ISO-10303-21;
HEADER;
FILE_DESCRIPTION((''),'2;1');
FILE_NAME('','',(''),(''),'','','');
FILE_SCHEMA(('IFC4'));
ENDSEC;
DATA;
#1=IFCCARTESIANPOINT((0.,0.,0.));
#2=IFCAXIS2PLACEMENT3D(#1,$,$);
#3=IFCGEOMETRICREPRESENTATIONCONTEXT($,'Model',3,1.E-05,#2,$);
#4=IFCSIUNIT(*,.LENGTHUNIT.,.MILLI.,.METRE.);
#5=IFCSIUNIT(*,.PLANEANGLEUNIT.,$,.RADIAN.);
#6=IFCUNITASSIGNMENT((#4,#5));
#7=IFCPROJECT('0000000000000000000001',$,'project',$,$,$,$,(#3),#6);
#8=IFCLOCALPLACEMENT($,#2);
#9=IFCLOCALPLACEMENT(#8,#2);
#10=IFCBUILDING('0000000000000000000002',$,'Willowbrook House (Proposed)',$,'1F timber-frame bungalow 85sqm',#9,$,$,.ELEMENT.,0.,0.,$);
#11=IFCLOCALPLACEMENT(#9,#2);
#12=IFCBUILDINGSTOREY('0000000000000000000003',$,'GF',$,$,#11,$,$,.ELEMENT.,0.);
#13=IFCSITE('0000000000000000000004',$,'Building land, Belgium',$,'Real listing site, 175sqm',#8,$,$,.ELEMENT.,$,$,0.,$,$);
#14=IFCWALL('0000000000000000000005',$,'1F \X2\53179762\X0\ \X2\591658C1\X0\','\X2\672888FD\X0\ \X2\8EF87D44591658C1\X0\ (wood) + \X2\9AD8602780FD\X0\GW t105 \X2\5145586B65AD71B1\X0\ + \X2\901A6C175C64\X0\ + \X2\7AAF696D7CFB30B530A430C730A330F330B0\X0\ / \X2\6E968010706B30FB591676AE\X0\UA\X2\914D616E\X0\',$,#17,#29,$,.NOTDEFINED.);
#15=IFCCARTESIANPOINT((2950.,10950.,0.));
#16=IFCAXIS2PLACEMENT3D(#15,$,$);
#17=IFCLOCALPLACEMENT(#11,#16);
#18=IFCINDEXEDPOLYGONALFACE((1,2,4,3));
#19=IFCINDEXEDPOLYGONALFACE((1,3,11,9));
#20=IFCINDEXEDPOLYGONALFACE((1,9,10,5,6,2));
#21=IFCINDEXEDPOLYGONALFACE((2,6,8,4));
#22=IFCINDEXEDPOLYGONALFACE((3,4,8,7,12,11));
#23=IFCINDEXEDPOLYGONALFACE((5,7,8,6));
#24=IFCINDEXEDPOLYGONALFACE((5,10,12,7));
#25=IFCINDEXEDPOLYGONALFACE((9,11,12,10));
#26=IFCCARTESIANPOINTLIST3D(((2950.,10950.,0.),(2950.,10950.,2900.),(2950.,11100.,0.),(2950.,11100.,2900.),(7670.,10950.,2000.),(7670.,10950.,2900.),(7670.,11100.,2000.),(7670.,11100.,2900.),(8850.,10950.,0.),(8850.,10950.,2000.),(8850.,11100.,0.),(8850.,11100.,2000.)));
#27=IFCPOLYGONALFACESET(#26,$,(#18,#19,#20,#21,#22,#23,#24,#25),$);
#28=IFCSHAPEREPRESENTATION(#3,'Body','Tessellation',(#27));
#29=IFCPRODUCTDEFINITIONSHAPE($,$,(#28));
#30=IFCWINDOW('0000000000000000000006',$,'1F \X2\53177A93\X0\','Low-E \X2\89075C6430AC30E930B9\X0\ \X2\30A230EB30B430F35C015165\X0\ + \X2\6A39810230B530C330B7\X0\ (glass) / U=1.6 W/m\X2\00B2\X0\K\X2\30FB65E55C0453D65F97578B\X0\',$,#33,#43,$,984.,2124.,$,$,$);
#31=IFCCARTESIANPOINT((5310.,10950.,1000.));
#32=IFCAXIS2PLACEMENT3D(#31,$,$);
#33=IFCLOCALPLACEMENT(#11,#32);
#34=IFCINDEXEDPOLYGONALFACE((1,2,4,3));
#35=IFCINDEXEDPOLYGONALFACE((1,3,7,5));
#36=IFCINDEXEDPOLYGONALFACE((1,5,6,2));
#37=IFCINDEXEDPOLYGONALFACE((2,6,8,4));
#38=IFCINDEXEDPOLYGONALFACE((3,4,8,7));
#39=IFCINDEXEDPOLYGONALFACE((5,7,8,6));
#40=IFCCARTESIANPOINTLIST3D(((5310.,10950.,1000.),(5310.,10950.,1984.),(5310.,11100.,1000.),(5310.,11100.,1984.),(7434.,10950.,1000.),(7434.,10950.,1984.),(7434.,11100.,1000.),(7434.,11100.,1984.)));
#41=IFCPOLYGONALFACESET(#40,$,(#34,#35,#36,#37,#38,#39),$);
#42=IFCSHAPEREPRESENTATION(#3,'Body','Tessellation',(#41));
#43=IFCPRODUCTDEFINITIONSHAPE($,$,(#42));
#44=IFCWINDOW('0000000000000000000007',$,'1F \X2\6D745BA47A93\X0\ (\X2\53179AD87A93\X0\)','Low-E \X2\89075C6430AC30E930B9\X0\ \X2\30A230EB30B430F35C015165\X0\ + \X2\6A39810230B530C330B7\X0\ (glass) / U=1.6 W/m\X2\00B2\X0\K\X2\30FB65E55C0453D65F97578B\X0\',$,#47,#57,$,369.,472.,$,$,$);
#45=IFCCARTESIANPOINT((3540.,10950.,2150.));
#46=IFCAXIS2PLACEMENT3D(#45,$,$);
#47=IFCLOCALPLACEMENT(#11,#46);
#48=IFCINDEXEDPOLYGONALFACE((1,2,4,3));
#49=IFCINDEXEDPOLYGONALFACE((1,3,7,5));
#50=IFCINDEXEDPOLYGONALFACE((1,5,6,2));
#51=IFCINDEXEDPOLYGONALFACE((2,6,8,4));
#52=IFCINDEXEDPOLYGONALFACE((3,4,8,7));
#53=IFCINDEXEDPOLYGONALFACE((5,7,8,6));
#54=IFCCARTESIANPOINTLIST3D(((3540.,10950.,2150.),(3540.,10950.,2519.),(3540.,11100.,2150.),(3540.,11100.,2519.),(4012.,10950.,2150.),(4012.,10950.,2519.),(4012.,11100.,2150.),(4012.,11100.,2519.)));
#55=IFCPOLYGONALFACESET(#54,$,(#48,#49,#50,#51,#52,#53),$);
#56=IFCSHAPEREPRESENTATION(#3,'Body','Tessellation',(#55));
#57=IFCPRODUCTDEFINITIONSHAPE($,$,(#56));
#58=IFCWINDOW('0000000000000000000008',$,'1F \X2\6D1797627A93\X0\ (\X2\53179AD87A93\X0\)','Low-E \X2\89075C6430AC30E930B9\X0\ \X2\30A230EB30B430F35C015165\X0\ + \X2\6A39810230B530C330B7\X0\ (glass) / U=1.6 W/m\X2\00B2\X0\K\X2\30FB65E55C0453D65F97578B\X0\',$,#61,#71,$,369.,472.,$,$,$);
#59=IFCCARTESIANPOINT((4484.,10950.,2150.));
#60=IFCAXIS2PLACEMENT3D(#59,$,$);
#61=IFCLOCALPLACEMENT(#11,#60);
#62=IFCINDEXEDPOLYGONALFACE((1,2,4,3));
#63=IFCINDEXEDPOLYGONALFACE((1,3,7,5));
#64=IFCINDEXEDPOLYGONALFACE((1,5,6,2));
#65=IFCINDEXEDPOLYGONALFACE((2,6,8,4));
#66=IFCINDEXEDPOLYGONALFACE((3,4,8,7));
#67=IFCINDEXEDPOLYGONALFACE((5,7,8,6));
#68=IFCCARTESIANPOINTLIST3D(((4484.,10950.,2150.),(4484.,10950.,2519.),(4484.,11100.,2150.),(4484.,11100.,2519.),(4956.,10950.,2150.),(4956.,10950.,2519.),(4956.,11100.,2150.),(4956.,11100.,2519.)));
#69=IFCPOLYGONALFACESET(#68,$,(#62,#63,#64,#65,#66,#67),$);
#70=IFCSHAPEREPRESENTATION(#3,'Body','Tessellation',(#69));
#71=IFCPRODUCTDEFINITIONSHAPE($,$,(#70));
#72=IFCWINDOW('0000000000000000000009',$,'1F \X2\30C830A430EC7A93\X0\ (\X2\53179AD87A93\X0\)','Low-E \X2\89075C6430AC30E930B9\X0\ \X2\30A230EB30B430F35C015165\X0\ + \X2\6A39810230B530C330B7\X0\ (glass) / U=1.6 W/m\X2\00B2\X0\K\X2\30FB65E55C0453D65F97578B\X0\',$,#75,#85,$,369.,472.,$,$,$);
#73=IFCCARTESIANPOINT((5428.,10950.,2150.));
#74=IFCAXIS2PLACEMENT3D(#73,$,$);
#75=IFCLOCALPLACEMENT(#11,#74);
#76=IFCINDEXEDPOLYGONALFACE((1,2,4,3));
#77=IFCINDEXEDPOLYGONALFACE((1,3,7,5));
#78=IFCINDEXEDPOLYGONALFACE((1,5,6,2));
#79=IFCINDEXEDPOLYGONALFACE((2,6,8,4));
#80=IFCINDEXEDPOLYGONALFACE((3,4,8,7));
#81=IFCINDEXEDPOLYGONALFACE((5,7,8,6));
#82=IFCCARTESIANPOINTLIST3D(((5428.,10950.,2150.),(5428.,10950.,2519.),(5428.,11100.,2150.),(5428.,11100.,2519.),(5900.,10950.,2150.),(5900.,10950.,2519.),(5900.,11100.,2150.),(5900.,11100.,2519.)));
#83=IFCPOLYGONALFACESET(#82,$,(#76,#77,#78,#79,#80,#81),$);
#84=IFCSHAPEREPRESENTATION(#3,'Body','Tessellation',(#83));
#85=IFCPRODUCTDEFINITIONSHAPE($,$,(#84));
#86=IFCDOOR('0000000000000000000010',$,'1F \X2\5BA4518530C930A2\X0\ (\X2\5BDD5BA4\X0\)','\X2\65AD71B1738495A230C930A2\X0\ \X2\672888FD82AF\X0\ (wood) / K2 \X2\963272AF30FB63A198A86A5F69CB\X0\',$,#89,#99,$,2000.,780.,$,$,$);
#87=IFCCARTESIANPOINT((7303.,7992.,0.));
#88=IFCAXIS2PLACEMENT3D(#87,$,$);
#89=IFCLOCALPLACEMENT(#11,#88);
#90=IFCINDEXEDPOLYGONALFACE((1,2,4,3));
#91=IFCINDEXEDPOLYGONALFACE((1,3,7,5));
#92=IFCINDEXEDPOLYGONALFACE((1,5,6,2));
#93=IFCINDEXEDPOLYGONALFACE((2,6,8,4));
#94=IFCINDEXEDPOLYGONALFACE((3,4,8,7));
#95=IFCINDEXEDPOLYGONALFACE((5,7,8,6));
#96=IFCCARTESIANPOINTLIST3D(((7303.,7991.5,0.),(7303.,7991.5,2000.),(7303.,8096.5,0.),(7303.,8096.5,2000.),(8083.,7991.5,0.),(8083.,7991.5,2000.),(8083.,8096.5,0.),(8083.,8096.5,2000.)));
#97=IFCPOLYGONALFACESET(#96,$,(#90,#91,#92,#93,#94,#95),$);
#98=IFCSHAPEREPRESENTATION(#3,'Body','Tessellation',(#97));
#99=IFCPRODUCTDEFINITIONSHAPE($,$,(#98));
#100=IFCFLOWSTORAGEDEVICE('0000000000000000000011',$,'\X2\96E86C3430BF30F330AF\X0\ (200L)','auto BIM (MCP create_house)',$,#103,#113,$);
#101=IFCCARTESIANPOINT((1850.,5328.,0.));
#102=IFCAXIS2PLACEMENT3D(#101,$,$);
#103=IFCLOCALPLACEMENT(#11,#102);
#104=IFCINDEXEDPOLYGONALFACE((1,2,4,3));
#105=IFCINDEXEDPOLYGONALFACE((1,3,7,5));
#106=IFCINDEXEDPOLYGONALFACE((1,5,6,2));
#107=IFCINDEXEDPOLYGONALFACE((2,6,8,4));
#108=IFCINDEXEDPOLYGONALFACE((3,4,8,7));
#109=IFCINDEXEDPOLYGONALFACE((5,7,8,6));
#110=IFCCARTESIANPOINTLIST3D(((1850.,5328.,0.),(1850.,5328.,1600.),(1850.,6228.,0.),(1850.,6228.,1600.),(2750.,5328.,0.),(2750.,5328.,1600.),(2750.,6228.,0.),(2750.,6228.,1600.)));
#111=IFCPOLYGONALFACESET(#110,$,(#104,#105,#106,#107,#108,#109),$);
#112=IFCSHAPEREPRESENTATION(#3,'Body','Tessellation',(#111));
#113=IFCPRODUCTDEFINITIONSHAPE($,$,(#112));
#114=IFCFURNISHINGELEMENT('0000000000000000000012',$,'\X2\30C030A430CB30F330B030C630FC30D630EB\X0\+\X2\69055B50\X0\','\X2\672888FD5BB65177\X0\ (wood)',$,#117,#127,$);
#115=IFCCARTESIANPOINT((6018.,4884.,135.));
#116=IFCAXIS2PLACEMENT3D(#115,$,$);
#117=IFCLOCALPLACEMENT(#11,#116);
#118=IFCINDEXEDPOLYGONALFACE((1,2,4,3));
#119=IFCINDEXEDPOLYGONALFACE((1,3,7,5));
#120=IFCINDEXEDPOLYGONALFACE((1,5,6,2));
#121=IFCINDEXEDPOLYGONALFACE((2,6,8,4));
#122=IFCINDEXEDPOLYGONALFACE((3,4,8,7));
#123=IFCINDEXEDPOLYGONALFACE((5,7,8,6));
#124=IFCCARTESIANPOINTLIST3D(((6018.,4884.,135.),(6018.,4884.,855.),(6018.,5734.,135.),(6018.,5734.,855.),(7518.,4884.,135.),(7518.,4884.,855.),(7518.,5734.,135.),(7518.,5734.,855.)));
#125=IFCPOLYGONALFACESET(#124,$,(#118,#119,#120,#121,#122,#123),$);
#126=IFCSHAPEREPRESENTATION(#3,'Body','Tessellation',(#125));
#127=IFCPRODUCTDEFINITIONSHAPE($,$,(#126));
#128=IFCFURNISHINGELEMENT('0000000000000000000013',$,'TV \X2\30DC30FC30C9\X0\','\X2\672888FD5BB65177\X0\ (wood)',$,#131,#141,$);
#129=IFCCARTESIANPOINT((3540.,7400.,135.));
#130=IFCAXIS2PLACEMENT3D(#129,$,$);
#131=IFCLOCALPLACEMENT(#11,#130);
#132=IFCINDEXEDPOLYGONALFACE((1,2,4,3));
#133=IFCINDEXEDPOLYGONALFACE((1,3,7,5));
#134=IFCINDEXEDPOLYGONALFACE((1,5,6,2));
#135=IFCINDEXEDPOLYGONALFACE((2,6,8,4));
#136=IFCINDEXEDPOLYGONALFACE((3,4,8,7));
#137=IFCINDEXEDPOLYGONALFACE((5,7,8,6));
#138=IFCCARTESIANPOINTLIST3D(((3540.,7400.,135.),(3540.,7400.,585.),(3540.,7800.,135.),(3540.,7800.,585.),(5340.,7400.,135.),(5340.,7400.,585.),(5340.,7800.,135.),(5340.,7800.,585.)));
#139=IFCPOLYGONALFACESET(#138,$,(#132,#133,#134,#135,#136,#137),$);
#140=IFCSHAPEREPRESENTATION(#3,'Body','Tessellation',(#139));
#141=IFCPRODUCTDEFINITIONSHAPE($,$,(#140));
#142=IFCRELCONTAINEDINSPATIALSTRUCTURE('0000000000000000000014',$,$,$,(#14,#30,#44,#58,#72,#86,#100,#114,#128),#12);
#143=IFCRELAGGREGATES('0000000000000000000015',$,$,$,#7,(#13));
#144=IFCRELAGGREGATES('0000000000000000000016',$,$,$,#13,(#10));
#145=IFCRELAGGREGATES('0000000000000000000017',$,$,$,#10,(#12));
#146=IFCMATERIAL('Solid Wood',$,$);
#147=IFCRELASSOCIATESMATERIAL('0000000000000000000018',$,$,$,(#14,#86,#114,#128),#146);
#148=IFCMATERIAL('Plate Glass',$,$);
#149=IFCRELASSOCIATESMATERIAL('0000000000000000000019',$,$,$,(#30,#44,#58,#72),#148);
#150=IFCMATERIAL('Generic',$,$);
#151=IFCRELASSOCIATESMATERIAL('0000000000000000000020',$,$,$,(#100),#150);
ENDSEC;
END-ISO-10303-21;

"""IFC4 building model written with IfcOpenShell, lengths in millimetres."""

from ifc_helpers import new_model, si_unit, frame, frame_2d, origin, place, context, project, spatial, rectangle, extrude, material, element, fill, save


model = new_model("IFC4")

# Units and contexts
model_context = context("Model", 3, precision=1e-05, world=origin())
ifc_project = project(units=[si_unit("LENGTHUNIT", "METRE", prefix="MILLI"), si_unit("PLANEANGLEUNIT", "RADIAN")], contexts=[model_context])

# Site, building, storey
site_placement = place(None, origin())
site = spatial("IfcSite", under=ifc_project, at=site_placement, Name="Building land, Belgium", ObjectType="Real listing site, 175sqm", CompositionType="ELEMENT", RefElevation=0.0)
building_placement = place(site_placement, origin())
building = spatial("IfcBuilding", under=site, at=building_placement, Name="Willowbrook House (Proposed)", ObjectType="1F timber-frame bungalow 85sqm", CompositionType="ELEMENT", ElevationOfRefHeight=0.0, ElevationOfTerrain=0.0)
storey_placement = place(building_placement, origin())
storey = spatial("IfcBuildingStorey", under=building, at=storey_placement, Name="GF", CompositionType="ELEMENT", Elevation=0.0)

# Wall, openings, windows
ifc_material_1 = material(Name="Solid Wood")
wall_1_placement = place(storey_placement, frame((2950.0, 10950.0, 0.0)))
wall_1 = element("IfcWall", 1, at=wall_1_placement, inside=storey, material=ifc_material_1, Name="1F 北面 外壁", Description="木製 軸組外壁 (wood) + 高性能GW t105 充填断熱 + 通気層 + 窯業系サイディング / 準耐火・外皮UA配慮", PredefinedType="NOTDEFINED", context=model_context, shape_type="SweptSolid", body=[
    extrude(rectangle(XDim=5900.0, YDim=150.0, at=frame_2d((2950.0, 75.0))), frame((2950.0, 10950.0, 0.0)), (0.0, 0.0, 1.0), 2900.0),
])
opening_1_placement = place(storey_placement, frame((5310.0, 10950.0, 1000.0)))
opening_1 = element("IfcOpeningElement", 2, at=opening_1_placement, cuts=wall_1, PredefinedType="NOTDEFINED", context=model_context, shape_type="SweptSolid", body=[
    extrude(rectangle(XDim=2124.0, YDim=150.0, at=frame_2d((1062.0, 75.0))), frame((5310.0, 10950.0, 1000.0)), (0.0, 0.0, 1.0), 984.0),
])
opening_2_placement = place(storey_placement, frame((3540.0, 10950.0, 2150.0)))
opening_2 = element("IfcOpeningElement", 3, at=opening_2_placement, cuts=wall_1, PredefinedType="NOTDEFINED", context=model_context, shape_type="SweptSolid", body=[
    extrude(rectangle(XDim=472.0, YDim=150.0, at=frame_2d((236.0, 75.0))), frame((3540.0, 10950.0, 2150.0)), (0.0, 0.0, 1.0), 369.0),
])
opening_3_placement = place(storey_placement, frame((4484.0, 10950.0, 2150.0)))
opening_3 = element("IfcOpeningElement", 4, at=opening_3_placement, cuts=wall_1, PredefinedType="NOTDEFINED", context=model_context, shape_type="SweptSolid", body=[
    extrude(rectangle(XDim=472.0, YDim=150.0, at=frame_2d((236.0, 75.0))), frame((4484.0, 10950.0, 2150.0)), (0.0, 0.0, 1.0), 369.0),
])
opening_4_placement = place(storey_placement, frame((5428.0, 10950.0, 2150.0)))
opening_4 = element("IfcOpeningElement", 5, at=opening_4_placement, cuts=wall_1, PredefinedType="NOTDEFINED", context=model_context, shape_type="SweptSolid", body=[
    extrude(rectangle(XDim=472.0, YDim=150.0, at=frame_2d((236.0, 75.0))), frame((5428.0, 10950.0, 2150.0)), (0.0, 0.0, 1.0), 369.0),
])
ifc_material_2 = material(Name="Plate Glass")
window_1_placement = place(storey_placement, frame((5310.0, 10950.0, 1000.0)))
window_1 = element("IfcWindow", 6, at=window_1_placement, inside=storey, material=ifc_material_2, Name="1F 北窓", Description="Low-E 複層ガラス アルゴン封入 + 樹脂サッシ (glass) / U=1.6 W/m²K・日射取得型", OverallHeight=984.0, OverallWidth=2124.0, context=model_context, shape_type="SweptSolid", body=[
    extrude(rectangle(XDim=2124.0, YDim=150.0, at=frame_2d((1062.0, 75.0))), frame((5310.0, 10950.0, 1000.0)), (0.0, 0.0, 1.0), 984.0),
])
fill(opening_1, window_1)
window_2_placement = place(storey_placement, frame((3540.0, 10950.0, 2150.0)))
window_2 = element("IfcWindow", 7, at=window_2_placement, inside=storey, material=ifc_material_2, Name="1F 浴室窓 (北高窓)", Description="Low-E 複層ガラス アルゴン封入 + 樹脂サッシ (glass) / U=1.6 W/m²K・日射取得型", OverallHeight=369.0, OverallWidth=472.0, context=model_context, shape_type="SweptSolid", body=[
    extrude(rectangle(XDim=472.0, YDim=150.0, at=frame_2d((236.0, 75.0))), frame((3540.0, 10950.0, 2150.0)), (0.0, 0.0, 1.0), 369.0),
])
fill(opening_2, window_2)
window_3_placement = place(storey_placement, frame((4484.0, 10950.0, 2150.0)))
window_3 = element("IfcWindow", 8, at=window_3_placement, inside=storey, material=ifc_material_2, Name="1F 洗面窓 (北高窓)", Description="Low-E 複層ガラス アルゴン封入 + 樹脂サッシ (glass) / U=1.6 W/m²K・日射取得型", OverallHeight=369.0, OverallWidth=472.0, context=model_context, shape_type="SweptSolid", body=[
    extrude(rectangle(XDim=472.0, YDim=150.0, at=frame_2d((236.0, 75.0))), frame((4484.0, 10950.0, 2150.0)), (0.0, 0.0, 1.0), 369.0),
])
fill(opening_3, window_3)
window_4_placement = place(storey_placement, frame((5428.0, 10950.0, 2150.0)))
window_4 = element("IfcWindow", 9, at=window_4_placement, inside=storey, material=ifc_material_2, Name="1F トイレ窓 (北高窓)", Description="Low-E 複層ガラス アルゴン封入 + 樹脂サッシ (glass) / U=1.6 W/m²K・日射取得型", OverallHeight=369.0, OverallWidth=472.0, context=model_context, shape_type="SweptSolid", body=[
    extrude(rectangle(XDim=472.0, YDim=150.0, at=frame_2d((236.0, 75.0))), frame((5428.0, 10950.0, 2150.0)), (0.0, 0.0, 1.0), 369.0),
])
fill(opening_4, window_4)

# Door
door_1_placement = place(storey_placement, frame((7303.0, 7992.0, 0.0)))
element("IfcDoor", 10, at=door_1_placement, inside=storey, material=ifc_material_1, Name="1F 室内ドア (寝室)", Description="断熱玄関ドア 木製芯 (wood) / K2 防犯・採風機構", OverallHeight=2000.0, OverallWidth=780.0, context=model_context, shape_type="SweptSolid", body=[
    extrude(rectangle(XDim=780.0, YDim=105.0, at=frame_2d((390.0, 52.0))), frame((7303.0, 7992.0, 0.0)), (0.0, 0.0, 1.0), 2000.0),
])

# Flow storage device
ifc_material_3 = material(Name="Generic")
flow_storage_device_placement = place(storey_placement, frame((1850.0, 5328.0, 0.0)))
element("IfcFlowStorageDevice", 11, at=flow_storage_device_placement, inside=storey, material=ifc_material_3, Name="雨水タンク (200L)", Description="auto BIM (MCP create_house)", context=model_context, shape_type="SweptSolid", body=[
    extrude(rectangle(XDim=900.0, YDim=900.0, at=frame_2d((450.0, 450.0))), frame((1850.0, 5328.0, 0.0)), (0.0, 0.0, 1.0), 1600.0),
])

# Furnishing elements
furnishing_1_placement = place(storey_placement, frame((6018.0, 4884.0, 135.0)))
element("IfcFurnishingElement", 12, at=furnishing_1_placement, inside=storey, material=ifc_material_1, Name="ダイニングテーブル+椅子", Description="木製家具 (wood)", context=model_context, shape_type="SweptSolid", body=[
    extrude(rectangle(XDim=1500.0, YDim=850.0, at=frame_2d((750.0, 425.0))), frame((6018.0, 4884.0, 135.0)), (0.0, 0.0, 1.0), 720.0),
])
furnishing_2_placement = place(storey_placement, frame((3540.0, 7400.0, 135.0)))
element("IfcFurnishingElement", 13, at=furnishing_2_placement, inside=storey, material=ifc_material_1, Name="TV ボード", Description="木製家具 (wood)", context=model_context, shape_type="SweptSolid", body=[
    extrude(rectangle(XDim=1800.0, YDim=400.0, at=frame_2d((900.0, 200.0))), frame((3540.0, 7400.0, 135.0)), (0.0, 0.0, 1.0), 450.0),
])

save(model, "model.ifc")
